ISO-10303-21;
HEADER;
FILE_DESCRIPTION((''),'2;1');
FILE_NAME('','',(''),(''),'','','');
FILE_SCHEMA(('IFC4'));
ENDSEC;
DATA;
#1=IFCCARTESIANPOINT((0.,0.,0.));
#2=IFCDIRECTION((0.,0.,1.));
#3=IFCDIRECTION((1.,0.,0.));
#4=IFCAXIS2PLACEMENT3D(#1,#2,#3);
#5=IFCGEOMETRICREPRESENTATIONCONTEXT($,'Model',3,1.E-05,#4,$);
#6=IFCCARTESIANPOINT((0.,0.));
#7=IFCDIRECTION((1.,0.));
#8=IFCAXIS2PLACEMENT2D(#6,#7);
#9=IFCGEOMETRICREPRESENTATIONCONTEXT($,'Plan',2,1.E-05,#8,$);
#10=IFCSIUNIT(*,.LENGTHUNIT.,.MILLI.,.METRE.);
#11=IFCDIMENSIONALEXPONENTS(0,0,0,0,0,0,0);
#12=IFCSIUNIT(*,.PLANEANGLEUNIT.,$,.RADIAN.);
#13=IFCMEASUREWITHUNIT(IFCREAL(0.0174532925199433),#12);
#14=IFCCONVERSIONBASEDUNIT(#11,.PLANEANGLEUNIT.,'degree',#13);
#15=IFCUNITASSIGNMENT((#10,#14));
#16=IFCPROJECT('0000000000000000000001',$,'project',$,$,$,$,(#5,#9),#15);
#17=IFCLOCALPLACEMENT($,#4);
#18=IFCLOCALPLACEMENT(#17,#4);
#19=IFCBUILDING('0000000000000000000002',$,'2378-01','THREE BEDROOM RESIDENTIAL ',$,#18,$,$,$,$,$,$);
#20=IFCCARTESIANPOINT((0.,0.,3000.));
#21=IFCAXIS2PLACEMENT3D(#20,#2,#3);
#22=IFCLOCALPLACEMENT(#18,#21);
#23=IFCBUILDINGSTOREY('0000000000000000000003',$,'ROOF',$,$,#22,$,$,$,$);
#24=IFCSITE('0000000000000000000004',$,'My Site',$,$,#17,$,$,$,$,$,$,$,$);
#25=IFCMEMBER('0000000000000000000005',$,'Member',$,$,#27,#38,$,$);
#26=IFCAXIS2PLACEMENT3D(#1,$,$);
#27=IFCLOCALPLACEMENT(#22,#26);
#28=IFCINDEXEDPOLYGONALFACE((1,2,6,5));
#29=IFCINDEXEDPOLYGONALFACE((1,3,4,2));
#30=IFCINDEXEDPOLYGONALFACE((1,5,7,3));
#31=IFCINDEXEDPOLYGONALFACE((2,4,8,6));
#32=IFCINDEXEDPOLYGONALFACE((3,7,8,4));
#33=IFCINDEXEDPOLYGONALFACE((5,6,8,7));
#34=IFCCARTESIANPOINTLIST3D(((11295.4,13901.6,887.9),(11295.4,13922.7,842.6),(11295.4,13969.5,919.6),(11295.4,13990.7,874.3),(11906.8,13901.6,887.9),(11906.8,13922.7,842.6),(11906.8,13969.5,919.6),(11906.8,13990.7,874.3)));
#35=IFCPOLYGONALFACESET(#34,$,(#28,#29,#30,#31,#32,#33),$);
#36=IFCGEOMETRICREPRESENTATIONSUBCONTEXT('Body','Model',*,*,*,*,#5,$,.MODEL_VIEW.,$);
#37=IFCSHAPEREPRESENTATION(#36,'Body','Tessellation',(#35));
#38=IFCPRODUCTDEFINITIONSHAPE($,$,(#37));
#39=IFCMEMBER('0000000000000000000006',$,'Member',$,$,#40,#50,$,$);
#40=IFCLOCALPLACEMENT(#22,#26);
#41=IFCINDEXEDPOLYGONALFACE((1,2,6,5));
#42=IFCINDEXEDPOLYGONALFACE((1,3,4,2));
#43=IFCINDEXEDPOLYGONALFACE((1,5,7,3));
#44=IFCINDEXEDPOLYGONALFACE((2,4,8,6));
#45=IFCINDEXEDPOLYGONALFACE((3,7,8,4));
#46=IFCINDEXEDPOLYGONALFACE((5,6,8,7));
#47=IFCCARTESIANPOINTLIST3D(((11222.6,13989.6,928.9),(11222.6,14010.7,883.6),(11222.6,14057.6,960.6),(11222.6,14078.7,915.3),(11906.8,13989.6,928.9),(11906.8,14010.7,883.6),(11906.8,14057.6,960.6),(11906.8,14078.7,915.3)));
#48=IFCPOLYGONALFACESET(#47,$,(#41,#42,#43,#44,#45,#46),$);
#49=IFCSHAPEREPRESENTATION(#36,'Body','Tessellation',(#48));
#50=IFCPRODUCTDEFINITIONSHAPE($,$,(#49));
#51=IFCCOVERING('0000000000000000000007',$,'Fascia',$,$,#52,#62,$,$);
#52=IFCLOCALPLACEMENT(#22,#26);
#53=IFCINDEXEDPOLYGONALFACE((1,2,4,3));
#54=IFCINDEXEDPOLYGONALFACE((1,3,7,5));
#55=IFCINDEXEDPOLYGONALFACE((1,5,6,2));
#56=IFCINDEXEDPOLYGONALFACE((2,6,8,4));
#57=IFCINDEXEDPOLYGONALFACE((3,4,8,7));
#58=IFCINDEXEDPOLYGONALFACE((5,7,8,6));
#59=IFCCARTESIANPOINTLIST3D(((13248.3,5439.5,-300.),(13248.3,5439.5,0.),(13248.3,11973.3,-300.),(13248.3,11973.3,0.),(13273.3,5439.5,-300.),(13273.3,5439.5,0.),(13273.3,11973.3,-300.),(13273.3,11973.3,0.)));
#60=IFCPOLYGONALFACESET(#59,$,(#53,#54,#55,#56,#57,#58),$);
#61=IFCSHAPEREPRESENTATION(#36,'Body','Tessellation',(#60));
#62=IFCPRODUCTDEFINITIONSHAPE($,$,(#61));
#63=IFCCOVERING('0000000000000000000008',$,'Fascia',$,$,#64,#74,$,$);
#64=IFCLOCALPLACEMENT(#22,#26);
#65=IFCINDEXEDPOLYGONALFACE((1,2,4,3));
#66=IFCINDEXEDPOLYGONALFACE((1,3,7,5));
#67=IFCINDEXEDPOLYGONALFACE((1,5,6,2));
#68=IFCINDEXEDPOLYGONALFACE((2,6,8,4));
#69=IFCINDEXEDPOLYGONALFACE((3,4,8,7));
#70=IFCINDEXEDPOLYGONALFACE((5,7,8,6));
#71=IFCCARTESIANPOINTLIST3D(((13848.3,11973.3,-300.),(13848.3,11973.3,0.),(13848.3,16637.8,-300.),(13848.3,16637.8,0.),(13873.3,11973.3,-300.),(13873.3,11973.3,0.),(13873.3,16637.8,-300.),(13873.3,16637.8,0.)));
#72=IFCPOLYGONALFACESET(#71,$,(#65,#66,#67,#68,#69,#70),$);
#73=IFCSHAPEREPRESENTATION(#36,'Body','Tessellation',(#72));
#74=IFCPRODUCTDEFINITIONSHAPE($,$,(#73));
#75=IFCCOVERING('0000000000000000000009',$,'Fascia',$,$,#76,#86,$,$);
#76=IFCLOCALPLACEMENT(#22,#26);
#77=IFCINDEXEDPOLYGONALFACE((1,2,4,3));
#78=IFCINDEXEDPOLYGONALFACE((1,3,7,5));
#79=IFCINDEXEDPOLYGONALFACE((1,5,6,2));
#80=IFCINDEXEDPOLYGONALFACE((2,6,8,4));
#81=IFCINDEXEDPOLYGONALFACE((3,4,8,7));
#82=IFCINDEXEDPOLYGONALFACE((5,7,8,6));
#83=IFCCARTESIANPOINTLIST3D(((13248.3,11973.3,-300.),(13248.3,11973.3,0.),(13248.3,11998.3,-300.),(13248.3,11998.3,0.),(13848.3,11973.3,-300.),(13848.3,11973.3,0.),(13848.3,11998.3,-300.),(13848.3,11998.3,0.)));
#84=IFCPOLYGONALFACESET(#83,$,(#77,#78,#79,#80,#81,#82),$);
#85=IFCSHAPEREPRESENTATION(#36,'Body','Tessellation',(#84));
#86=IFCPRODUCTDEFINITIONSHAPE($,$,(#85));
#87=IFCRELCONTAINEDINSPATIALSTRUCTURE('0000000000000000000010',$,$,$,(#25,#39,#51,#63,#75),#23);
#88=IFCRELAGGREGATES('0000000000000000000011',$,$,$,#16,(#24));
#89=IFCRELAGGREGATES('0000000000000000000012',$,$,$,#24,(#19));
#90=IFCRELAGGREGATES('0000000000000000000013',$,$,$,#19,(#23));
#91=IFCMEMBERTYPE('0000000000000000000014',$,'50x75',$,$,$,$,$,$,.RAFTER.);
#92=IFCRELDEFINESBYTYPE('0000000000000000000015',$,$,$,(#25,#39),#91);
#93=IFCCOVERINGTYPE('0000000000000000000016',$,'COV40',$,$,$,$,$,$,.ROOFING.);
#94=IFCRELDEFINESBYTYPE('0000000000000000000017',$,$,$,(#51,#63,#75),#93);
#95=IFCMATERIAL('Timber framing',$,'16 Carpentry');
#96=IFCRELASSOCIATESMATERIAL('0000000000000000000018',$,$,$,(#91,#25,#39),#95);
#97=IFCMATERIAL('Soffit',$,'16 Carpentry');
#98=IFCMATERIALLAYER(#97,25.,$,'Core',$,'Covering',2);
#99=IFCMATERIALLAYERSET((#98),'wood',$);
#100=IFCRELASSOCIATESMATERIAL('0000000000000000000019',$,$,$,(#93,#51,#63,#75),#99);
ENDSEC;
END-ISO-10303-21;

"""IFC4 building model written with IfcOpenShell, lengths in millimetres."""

from ifc_helpers import new_model, entity, si_unit, converted_unit, frame, origin_with_axes, origin_2d_with_axis, place, context, subcontext, project, spatial, indexed_curve, rectangle, outline, extrude, material, layer, layer_set, layer_usage, material_profile, profile_set, profile_usage, type_object, element, save


model = new_model("IFC4")

# Units and contexts
model_context = context("Model", 3, precision=1e-05, world=origin_with_axes())
plan_context = context("Plan", 2, precision=1e-05, world=origin_2d_with_axis())
body_context = subcontext(model_context, "Body", "Model", "MODEL_VIEW")
ifc_project = project(units=[si_unit("LENGTHUNIT", "METRE", prefix="MILLI"), converted_unit("PLANEANGLEUNIT", "degree", entity("IfcReal", 0.0174532925199433), si_unit("PLANEANGLEUNIT", "RADIAN"), dimensions=[0, 0, 0, 0, 0, 0, 0])], contexts=[model_context, plan_context])

# Site, building, storey
site_placement = place(None, origin_with_axes())
site = spatial("IfcSite", under=ifc_project, at=site_placement, Name="My Site")
building_placement = place(site_placement, origin_with_axes())
building = spatial("IfcBuilding", under=site, at=building_placement, Name="2378-01", Description="THREE BEDROOM RESIDENTIAL ")
storey_placement = place(building_placement, frame((0.0, 0.0, 3000.0), z_axis=(0.0, 0.0, 1.0), x_axis=(1.0, 0.0, 0.0)))
storey = spatial("IfcBuildingStorey", under=building, at=storey_placement, Name="ROOF")

# Members
ifc_material_1 = material(Name="Timber framing", Category="16 Carpentry")
ifc_material_profile_1 = material_profile(ifc_material_1, rectangle(XDim=50.0, YDim=75.0), Name="Lumber2", Category="Substrate", Priority=2)
ifc_profile_set_1 = profile_set([ifc_material_profile_1])
member_type_1 = type_object("IfcMemberType", Name="50x75", PredefinedType="RAFTER", material=ifc_profile_set_1)
ifc_profile_usage_1 = profile_usage(ifc_profile_set_1, cardinal=5)
member_1_placement = place(storey_placement, frame((11906.8, 13946.1, 881.1), z_axis=(-1.0, 0.0, 0.0), x_axis=(0.0, -0.422618, 0.906308)))
element("IfcMember", 1, at=member_1_placement, inside=storey, type_object=member_type_1, material=ifc_profile_usage_1, Name="Member", context=body_context, shape_type="SweptSolid", body=[
    extrude(rectangle(XDim=50.0, YDim=75.0), origin_with_axes(), (0.0, 0.0, 1.0), 611.4),
])
ifc_profile_usage_2 = profile_usage(ifc_profile_set_1, cardinal=5)
member_2_placement = place(storey_placement, frame((11906.8, 14034.1, 922.1), z_axis=(-1.0, 0.0, 0.0), x_axis=(0.0, -0.422618, 0.906308)))
element("IfcMember", 2, at=member_2_placement, inside=storey, type_object=member_type_1, material=ifc_profile_usage_2, Name="Member", context=body_context, shape_type="SweptSolid", body=[
    extrude(rectangle(XDim=50.0, YDim=75.0), origin_with_axes(), (0.0, 0.0, 1.0), 684.2),
])

# Coverings
ifc_material_2 = material(Name="Soffit", Category="16 Carpentry")
ifc_layer = layer(ifc_material_2, 25.0, Name="Core", Category="Covering", Priority=2)
ifc_layer_set = layer_set([ifc_layer], Name="wood")
ifc_layer_usage_1 = layer_usage(ifc_layer_set, "AXIS2", "POSITIVE", 0.0)
covering_type = type_object("IfcCoveringType", Name="COV40", PredefinedType="ROOFING", material=ifc_layer_set)
covering_1_placement = place(storey_placement, frame((13248.3, 11973.3, -300.0), z_axis=(0.0, 0.0, 1.0), x_axis=(0.0, -1.0, 0.0)))
element("IfcCovering", 3, at=covering_1_placement, inside=storey, type_object=covering_type, material=ifc_layer_usage_1, Name="Fascia", context=body_context, shape_type="SweptSolid", body=[
    extrude(outline(indexed_curve([(0.0, 0.0), (0.0, 25.0), (6533.8, 25.0), (6533.8, 0.0), (0.0, 0.0)], self_intersect=False)), origin_with_axes(), (0.0, 0.0, 1.0), 300.0),
])
ifc_layer_usage_2 = layer_usage(ifc_layer_set, "AXIS2", "POSITIVE", 0.0)
covering_2_placement = place(storey_placement, frame((13848.3, 16637.8, -300.0), z_axis=(0.0, 0.0, 1.0), x_axis=(0.0, -1.0, 0.0)))
element("IfcCovering", 4, at=covering_2_placement, inside=storey, type_object=covering_type, material=ifc_layer_usage_2, Name="Fascia", context=body_context, shape_type="SweptSolid", body=[
    extrude(outline(indexed_curve([(0.0, 0.0), (0.0, 25.0), (4664.5, 25.0), (4664.5, 0.0), (0.0, 0.0)], self_intersect=False)), origin_with_axes(), (0.0, 0.0, 1.0), 300.0),
])
ifc_layer_usage_3 = layer_usage(ifc_layer_set, "AXIS2", "POSITIVE", 0.0)
covering_3_placement = place(storey_placement, frame((13248.3, 11973.3, -300.0), z_axis=(0.0, 0.0, 1.0), x_axis=(1.0, 0.0, 0.0)))
element("IfcCovering", 5, at=covering_3_placement, inside=storey, type_object=covering_type, material=ifc_layer_usage_3, Name="Fascia", context=body_context, shape_type="SweptSolid", body=[
    extrude(outline(indexed_curve([(0.0, 0.0), (0.0, 25.0), (600.0, 25.0), (600.0, 0.0), (0.0, 0.0)], self_intersect=False)), origin_with_axes(), (0.0, 0.0, 1.0), 300.0),
])

save(model, "model.ifc")
